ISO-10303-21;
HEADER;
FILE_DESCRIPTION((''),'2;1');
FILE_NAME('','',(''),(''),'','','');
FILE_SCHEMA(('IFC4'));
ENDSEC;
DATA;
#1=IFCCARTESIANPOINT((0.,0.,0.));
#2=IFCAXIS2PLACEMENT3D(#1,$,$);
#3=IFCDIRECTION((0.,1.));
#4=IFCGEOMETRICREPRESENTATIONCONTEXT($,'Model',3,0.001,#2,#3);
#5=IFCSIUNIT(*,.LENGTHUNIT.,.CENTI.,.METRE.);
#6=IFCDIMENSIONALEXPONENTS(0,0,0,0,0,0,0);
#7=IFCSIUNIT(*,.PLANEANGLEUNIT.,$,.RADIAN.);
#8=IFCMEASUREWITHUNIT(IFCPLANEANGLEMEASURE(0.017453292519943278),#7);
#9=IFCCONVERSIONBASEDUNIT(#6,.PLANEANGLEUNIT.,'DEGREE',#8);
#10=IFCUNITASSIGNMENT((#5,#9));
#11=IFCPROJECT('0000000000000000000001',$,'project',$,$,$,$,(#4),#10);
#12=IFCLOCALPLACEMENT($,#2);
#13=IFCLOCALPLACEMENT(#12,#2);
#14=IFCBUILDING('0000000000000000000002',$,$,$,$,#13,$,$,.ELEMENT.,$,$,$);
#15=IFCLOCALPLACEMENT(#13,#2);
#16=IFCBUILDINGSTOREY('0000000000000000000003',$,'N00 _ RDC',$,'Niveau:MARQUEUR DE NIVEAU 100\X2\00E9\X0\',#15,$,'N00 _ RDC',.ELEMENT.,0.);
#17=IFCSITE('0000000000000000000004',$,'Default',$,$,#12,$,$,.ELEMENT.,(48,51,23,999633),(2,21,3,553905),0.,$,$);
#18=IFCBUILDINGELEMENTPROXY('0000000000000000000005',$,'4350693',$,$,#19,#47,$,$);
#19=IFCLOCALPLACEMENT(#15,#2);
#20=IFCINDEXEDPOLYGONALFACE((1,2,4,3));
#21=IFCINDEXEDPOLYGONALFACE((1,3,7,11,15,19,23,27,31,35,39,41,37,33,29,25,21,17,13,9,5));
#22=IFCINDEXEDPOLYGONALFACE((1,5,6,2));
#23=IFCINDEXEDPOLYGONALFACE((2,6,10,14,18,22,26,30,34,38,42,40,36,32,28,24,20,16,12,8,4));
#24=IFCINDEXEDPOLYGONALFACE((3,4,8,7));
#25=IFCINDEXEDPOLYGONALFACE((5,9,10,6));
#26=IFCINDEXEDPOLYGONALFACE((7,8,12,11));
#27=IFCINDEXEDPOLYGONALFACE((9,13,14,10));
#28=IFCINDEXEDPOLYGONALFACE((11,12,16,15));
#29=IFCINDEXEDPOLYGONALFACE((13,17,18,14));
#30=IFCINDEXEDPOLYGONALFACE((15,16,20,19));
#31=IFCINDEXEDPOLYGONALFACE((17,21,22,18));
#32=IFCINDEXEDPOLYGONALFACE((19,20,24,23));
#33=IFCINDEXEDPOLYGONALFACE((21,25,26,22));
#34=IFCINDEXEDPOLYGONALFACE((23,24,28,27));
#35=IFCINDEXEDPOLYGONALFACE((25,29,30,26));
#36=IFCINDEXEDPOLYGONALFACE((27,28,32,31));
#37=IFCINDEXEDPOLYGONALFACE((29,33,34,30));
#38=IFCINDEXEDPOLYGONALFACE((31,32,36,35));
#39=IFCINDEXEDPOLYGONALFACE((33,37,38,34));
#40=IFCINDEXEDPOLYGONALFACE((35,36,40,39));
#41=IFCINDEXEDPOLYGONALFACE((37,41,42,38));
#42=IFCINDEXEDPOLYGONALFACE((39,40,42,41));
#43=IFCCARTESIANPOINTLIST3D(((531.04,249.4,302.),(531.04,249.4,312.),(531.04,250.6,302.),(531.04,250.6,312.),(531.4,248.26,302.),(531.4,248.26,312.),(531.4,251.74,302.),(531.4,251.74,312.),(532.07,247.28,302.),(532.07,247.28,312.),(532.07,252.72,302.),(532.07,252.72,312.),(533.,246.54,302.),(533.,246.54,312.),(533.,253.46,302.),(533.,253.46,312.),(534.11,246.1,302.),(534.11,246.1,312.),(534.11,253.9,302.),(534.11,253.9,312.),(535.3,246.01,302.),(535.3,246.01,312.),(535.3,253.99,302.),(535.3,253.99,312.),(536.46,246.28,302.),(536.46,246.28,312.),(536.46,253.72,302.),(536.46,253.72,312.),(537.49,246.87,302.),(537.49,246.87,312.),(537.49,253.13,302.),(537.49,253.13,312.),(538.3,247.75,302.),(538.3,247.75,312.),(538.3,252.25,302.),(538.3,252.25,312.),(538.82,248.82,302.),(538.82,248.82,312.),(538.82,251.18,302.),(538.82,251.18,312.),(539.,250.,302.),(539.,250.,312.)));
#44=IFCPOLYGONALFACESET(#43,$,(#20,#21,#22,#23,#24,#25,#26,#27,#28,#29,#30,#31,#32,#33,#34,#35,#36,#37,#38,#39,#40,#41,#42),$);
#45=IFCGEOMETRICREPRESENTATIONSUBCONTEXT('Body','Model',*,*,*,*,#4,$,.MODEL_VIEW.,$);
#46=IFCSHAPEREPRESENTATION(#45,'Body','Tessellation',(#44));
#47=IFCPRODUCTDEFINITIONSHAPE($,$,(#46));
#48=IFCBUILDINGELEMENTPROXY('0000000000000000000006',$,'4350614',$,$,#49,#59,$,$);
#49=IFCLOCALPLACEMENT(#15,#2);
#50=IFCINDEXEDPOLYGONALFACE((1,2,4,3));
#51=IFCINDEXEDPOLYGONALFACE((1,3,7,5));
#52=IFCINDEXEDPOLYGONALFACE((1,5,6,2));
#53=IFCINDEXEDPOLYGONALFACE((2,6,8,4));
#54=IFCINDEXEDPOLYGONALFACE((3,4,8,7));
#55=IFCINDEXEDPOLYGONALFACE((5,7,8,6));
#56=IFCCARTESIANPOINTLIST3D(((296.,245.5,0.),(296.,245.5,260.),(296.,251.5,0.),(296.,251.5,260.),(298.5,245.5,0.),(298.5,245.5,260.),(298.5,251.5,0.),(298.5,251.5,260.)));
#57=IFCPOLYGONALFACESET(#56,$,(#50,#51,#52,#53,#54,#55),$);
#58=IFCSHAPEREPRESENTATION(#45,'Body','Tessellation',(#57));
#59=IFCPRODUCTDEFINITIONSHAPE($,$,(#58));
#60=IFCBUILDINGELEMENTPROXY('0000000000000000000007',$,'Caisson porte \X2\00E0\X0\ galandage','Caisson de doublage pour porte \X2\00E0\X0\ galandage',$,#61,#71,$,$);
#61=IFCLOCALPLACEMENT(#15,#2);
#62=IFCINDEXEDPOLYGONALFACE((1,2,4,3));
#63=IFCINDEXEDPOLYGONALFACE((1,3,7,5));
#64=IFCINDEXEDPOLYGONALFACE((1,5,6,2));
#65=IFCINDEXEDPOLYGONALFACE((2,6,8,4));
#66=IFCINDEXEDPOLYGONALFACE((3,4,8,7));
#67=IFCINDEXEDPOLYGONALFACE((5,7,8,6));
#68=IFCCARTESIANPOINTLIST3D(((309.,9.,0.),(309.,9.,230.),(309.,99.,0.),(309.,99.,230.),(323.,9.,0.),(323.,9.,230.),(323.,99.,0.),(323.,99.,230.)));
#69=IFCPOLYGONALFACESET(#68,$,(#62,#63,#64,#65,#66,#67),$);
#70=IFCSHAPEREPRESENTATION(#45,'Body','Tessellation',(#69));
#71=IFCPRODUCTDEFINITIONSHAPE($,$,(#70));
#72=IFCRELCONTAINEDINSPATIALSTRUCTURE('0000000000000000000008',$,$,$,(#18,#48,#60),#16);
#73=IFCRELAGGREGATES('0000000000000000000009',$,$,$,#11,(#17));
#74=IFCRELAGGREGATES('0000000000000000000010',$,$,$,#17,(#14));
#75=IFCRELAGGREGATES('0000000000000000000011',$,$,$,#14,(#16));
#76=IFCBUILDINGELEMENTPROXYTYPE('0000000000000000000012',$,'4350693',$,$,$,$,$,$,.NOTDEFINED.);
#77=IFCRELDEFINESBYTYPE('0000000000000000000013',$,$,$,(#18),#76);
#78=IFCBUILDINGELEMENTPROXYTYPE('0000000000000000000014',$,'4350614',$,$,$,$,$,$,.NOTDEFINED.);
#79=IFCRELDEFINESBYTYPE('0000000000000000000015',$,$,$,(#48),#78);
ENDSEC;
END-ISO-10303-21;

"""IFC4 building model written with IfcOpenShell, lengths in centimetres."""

from ifc_helpers import new_model, entity, si_unit, converted_unit, direction, frame, frame_2d, origin, origin_with_axes, origin_2d_with_axis, place, context, subcontext, project, spatial, rectangle, circle, extrude, type_object, element, save


model = new_model("IFC4")

# Units and contexts
model_context = context("Model", 3, precision=0.001, world=origin(), true_north=direction((0.0, 1.0)))
body_context = subcontext(model_context, "Body", "Model", "MODEL_VIEW")
ifc_project = project(units=[si_unit("LENGTHUNIT", "METRE", prefix="CENTI"), converted_unit("PLANEANGLEUNIT", "DEGREE", entity("IfcPlaneAngleMeasure", 0.017453292519943278), si_unit("PLANEANGLEUNIT", "RADIAN"), dimensions=[0, 0, 0, 0, 0, 0, 0])], contexts=[model_context])

# Site, building, storey
site_placement = place(None, origin())
site = spatial("IfcSite", under=ifc_project, at=site_placement, Name="Default", CompositionType="ELEMENT", RefLatitude=(48, 51, 23, 999633), RefLongitude=(2, 21, 3, 553905), RefElevation=0.0)
building_placement = place(site_placement, origin())
building = spatial("IfcBuilding", under=site, at=building_placement, CompositionType="ELEMENT")
storey_placement = place(building_placement, origin())
storey = spatial("IfcBuildingStorey", under=building, at=storey_placement, Name="N00 _ RDC", ObjectType="Niveau:MARQUEUR DE NIVEAU 100é", LongName="N00 _ RDC", CompositionType="ELEMENT", Elevation=0.0)

# Building element proxies
building_element_proxy_type_1 = type_object("IfcBuildingElementProxyType", Name="4350693", PredefinedType="NOTDEFINED")
proxy_1_placement = place(storey_placement, origin())
element("IfcBuildingElementProxy", 1, at=proxy_1_placement, inside=storey, type_object=building_element_proxy_type_1, Name="4350693", context=body_context, shape_type="SweptSolid", body=[
    extrude(circle(Radius=4.0, at=origin_2d_with_axis()), frame((535.0, 250.0, 302.0)), (0.0, 0.0, 1.0), 10.0),
])
building_element_proxy_type_2 = type_object("IfcBuildingElementProxyType", Name="4350614", PredefinedType="NOTDEFINED")
proxy_2_placement = place(storey_placement, origin())
element("IfcBuildingElementProxy", 2, at=proxy_2_placement, inside=storey, type_object=building_element_proxy_type_2, Name="4350614", context=body_context, shape_type="SweptSolid", body=[
    extrude(rectangle(XDim=2.5, YDim=6.0, at=frame_2d((0.0, 0.0), x_axis=(1.0, 0.0))), frame((297.25, 248.5, 0.0)), (0.0, 0.0, 1.0), 260.0),
])
proxy_3_placement = place(storey_placement, origin_with_axes())
element("IfcBuildingElementProxy", 3, at=proxy_3_placement, inside=storey, Name="Caisson porte à galandage", Description="Caisson de doublage pour porte à galandage", context=body_context, shape_type="SweptSolid", body=[
    extrude(rectangle(XDim=14.0, YDim=90.0, at=frame_2d((316.0, 54.0))), origin(), (0.0, 0.0, 1.0), 230.0),
])

save(model, "model.ifc")
